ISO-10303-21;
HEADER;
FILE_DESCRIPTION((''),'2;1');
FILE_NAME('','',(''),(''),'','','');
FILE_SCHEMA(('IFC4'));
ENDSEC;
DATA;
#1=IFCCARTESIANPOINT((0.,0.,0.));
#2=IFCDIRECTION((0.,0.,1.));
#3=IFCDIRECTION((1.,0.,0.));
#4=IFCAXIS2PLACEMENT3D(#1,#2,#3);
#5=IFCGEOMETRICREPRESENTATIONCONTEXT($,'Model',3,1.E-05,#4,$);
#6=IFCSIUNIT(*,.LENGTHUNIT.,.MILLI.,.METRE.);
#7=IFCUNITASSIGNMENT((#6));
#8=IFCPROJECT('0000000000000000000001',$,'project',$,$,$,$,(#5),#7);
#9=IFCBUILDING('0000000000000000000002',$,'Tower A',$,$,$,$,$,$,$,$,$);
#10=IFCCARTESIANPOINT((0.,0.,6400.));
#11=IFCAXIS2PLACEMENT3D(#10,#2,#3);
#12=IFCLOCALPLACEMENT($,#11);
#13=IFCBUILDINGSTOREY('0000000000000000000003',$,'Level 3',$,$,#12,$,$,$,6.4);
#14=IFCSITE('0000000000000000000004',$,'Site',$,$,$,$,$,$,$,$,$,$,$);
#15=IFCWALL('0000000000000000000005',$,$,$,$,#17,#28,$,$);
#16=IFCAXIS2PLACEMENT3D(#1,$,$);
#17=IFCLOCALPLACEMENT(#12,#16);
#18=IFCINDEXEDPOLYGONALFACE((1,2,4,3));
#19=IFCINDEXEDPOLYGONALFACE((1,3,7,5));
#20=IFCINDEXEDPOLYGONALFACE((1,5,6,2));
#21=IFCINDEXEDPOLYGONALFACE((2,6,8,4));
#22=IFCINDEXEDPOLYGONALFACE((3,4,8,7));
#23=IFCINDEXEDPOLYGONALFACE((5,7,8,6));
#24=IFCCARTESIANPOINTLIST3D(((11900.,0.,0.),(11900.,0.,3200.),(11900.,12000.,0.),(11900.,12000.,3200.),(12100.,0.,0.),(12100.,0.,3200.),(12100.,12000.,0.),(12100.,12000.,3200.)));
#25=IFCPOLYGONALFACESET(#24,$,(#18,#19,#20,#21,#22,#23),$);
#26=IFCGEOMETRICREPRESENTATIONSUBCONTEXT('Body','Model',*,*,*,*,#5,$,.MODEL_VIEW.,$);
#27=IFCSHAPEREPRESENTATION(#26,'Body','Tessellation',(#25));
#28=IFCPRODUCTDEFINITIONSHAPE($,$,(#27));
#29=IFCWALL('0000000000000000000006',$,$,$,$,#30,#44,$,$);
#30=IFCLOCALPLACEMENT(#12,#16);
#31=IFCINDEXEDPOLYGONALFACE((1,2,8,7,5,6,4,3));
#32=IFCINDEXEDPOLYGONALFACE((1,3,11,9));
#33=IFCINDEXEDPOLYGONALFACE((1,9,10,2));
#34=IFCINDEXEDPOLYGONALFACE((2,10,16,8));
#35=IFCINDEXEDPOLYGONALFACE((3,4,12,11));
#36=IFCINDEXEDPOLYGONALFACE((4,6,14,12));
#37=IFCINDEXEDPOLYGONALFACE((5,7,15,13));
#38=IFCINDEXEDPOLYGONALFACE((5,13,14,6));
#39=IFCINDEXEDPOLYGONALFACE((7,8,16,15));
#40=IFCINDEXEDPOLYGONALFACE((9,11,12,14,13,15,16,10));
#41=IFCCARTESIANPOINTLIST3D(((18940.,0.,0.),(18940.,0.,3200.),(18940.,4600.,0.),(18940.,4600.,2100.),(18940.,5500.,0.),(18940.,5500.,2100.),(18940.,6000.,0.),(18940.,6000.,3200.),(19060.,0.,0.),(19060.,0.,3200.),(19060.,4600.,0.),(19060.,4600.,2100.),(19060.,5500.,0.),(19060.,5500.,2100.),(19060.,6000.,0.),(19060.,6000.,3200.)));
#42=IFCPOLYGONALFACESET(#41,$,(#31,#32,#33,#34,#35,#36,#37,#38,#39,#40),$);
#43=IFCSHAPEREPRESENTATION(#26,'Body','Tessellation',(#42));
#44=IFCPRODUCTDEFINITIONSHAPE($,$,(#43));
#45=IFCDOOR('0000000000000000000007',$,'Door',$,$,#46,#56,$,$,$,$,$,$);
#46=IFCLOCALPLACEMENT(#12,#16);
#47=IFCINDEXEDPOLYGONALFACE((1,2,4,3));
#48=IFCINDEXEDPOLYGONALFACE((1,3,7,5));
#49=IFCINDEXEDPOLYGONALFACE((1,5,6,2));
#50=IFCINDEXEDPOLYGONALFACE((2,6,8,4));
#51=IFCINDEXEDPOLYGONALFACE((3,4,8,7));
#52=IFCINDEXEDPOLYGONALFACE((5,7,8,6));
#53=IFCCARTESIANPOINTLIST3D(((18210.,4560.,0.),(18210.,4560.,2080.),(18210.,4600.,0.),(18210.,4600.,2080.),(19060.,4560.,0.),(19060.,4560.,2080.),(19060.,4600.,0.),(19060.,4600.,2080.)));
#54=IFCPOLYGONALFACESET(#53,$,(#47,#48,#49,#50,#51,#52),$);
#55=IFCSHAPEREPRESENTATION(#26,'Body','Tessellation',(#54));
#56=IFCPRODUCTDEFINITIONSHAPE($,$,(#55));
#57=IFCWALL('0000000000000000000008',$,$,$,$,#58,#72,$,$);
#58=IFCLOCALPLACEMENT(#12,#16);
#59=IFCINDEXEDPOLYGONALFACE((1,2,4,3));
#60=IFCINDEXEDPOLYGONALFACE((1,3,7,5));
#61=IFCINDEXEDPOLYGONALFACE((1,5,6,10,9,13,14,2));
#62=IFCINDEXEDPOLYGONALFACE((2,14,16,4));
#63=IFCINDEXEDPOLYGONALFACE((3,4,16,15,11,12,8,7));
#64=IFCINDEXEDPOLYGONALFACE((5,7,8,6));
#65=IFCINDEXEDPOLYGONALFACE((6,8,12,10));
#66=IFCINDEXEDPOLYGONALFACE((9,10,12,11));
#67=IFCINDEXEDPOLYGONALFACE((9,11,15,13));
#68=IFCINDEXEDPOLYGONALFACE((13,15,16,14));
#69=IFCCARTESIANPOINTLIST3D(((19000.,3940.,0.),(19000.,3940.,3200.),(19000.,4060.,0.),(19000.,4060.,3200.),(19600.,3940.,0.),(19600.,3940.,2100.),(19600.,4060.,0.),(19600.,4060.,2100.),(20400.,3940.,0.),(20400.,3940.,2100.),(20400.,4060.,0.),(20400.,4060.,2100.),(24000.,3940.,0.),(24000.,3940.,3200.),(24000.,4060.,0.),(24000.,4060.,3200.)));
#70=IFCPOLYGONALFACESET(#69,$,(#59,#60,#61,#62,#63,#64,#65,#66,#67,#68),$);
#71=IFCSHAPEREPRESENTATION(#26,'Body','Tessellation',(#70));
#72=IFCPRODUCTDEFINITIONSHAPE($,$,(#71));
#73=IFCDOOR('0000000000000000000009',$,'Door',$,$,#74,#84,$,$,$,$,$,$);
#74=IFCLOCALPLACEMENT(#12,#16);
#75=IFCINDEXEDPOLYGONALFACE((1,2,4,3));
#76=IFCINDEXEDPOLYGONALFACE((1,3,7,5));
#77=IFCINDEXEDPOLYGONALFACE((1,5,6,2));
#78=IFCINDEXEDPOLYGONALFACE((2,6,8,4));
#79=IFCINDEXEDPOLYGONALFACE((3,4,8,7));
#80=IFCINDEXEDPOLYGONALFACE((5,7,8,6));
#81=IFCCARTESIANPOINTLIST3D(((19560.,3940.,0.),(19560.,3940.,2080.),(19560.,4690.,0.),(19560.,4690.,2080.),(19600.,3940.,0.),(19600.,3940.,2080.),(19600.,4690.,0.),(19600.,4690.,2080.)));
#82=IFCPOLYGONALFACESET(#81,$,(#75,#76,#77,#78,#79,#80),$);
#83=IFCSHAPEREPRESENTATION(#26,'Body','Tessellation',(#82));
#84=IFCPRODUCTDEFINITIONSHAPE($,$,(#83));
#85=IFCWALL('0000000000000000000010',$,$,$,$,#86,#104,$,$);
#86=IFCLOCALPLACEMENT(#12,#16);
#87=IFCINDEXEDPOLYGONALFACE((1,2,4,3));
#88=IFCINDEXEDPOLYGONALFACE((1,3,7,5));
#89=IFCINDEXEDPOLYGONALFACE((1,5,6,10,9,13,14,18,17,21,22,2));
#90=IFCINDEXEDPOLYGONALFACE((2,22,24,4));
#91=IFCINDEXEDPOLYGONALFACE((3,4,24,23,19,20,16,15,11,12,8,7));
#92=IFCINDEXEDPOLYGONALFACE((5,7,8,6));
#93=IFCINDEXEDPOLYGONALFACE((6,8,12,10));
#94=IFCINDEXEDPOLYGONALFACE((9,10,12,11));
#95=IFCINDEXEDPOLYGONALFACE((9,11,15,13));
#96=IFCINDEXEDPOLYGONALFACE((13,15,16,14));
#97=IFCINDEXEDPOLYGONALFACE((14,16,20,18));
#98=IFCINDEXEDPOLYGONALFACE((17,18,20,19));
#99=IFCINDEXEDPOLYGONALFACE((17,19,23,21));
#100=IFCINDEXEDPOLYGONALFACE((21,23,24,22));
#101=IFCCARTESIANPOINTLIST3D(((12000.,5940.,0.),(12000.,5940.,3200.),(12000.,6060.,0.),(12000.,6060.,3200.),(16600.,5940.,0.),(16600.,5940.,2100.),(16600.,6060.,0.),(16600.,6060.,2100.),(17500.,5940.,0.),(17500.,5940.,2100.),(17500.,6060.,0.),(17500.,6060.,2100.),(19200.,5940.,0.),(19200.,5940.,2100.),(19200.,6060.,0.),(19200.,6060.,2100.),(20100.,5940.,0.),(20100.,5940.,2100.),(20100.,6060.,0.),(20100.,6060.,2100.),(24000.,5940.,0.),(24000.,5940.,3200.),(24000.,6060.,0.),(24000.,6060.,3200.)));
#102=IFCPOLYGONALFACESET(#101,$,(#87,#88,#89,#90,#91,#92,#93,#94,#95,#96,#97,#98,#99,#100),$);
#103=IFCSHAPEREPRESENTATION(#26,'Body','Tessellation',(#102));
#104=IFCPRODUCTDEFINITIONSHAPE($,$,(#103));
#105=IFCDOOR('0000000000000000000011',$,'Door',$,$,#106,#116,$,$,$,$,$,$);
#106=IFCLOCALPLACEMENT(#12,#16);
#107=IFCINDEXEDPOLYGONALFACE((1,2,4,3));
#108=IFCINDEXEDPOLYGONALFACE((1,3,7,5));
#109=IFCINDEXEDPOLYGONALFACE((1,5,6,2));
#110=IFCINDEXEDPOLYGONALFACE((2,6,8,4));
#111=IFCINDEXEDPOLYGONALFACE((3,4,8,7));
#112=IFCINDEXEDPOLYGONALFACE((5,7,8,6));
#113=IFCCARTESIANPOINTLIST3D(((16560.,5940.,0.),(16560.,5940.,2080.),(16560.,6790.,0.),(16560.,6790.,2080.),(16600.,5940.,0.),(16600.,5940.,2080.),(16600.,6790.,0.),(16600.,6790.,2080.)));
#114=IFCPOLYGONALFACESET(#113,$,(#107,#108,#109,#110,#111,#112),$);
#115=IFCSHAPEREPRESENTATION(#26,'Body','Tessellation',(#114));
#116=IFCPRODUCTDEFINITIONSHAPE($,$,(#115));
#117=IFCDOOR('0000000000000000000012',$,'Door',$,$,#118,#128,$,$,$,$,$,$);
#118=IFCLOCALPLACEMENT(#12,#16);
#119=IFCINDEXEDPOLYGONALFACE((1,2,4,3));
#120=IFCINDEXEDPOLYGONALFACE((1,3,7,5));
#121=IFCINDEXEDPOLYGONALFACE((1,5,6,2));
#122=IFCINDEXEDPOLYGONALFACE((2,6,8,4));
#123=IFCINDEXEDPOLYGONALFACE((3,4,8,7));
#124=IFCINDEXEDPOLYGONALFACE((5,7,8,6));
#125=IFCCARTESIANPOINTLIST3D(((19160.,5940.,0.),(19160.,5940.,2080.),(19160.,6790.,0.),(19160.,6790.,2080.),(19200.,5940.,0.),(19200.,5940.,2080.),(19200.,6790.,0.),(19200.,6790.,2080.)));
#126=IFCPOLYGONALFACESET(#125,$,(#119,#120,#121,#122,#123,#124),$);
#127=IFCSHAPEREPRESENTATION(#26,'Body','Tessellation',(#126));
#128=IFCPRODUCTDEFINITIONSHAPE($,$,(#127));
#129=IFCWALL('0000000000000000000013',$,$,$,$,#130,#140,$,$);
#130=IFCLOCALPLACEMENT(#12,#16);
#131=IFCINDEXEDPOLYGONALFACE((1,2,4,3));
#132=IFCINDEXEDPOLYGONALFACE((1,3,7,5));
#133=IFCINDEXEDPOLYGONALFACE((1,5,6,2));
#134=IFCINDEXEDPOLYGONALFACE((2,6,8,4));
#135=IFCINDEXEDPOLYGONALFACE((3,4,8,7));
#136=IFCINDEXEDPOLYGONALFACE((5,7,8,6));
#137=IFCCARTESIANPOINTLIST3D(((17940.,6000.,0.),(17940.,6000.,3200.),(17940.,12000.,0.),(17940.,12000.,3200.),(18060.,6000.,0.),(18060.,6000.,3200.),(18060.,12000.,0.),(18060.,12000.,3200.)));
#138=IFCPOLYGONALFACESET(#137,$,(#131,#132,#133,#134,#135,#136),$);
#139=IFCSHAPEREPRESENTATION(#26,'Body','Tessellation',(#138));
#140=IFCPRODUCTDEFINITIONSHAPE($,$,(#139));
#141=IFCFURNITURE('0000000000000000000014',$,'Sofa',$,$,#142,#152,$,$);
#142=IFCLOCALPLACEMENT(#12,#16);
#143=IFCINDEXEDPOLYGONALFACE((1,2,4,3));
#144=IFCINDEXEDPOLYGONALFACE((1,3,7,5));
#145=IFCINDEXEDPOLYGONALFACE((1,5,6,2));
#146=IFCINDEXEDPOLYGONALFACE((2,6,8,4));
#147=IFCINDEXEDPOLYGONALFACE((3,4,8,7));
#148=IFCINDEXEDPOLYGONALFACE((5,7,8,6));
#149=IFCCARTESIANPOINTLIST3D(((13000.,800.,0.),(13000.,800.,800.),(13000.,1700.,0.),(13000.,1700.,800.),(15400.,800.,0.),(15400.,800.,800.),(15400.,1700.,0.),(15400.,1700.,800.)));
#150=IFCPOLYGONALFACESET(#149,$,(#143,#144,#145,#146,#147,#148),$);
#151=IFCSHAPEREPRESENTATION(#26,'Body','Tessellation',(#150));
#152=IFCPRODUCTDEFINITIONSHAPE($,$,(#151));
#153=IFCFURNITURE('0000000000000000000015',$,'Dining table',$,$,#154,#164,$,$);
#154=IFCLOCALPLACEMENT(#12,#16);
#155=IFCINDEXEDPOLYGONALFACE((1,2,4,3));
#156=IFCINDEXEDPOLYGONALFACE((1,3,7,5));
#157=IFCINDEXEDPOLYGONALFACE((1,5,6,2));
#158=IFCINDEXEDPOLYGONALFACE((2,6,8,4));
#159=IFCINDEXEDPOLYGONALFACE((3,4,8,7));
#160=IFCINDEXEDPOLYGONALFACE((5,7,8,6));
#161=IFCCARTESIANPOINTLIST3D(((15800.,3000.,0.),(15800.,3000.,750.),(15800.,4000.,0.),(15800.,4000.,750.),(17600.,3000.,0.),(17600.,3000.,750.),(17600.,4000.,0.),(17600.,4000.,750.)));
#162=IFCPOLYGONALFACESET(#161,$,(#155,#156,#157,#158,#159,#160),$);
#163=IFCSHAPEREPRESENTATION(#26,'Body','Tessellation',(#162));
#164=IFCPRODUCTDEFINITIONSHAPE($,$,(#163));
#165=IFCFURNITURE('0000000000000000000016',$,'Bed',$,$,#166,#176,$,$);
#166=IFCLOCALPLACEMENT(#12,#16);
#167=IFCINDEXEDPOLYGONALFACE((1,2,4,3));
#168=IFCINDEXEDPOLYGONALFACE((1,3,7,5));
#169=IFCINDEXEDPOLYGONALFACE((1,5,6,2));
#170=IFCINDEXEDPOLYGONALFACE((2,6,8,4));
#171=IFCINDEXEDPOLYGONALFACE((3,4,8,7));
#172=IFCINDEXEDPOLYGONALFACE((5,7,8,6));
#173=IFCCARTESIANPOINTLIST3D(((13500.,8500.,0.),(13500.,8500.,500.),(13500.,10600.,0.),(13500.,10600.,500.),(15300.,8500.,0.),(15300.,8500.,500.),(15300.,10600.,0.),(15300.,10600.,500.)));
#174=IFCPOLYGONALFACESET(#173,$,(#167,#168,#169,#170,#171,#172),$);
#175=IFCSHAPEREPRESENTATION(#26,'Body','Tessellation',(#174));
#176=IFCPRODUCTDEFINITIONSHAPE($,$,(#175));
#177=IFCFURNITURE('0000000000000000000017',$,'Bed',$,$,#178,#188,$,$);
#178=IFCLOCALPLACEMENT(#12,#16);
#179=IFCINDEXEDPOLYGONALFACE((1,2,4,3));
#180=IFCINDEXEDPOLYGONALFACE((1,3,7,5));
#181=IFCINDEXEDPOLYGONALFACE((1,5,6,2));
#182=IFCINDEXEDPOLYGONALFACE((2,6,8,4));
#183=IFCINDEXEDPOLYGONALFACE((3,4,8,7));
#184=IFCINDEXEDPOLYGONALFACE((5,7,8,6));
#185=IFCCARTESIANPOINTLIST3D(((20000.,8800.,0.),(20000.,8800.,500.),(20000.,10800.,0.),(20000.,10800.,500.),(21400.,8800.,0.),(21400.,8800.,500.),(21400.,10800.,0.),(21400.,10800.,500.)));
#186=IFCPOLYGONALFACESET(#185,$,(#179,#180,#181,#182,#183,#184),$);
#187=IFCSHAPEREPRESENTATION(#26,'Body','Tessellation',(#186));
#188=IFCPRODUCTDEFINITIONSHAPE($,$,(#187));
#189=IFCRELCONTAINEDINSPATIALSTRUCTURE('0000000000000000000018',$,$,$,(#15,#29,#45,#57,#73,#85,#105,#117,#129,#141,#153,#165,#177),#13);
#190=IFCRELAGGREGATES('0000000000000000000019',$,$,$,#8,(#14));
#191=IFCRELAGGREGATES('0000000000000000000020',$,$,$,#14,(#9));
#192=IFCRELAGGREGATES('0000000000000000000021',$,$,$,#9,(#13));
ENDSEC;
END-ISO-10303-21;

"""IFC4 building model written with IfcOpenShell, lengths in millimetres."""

from ifc_helpers import new_model, si_unit, frame, origin_with_axes, place, context, subcontext, project, spatial, indexed_curve, outline, extrude, element, fill, save


model = new_model("IFC4")

# Units and contexts
model_context = context("Model", 3, precision=1e-05, world=origin_with_axes())
body_context = subcontext(model_context, "Body", "Model", "MODEL_VIEW")
ifc_project = project(units=[si_unit("LENGTHUNIT", "METRE", prefix="MILLI")], contexts=[model_context])

# Site, building, storey
site = spatial("IfcSite", under=ifc_project, Name="Site")
building = spatial("IfcBuilding", under=site, Name="Tower A")
storey_placement = place(None, frame((0.0, 0.0, 6400.0), z_axis=(0.0, 0.0, 1.0), x_axis=(1.0, 0.0, 0.0)))
storey = spatial("IfcBuildingStorey", under=building, at=storey_placement, Name="Level 3", Elevation=6.4)

# Wall
wall_1_placement = place(storey_placement, frame((12100.0, 0.0, 0.0), z_axis=(0.0, 0.0, 1.0), x_axis=(0.0, 1.0, 0.0)))
element("IfcWall", 1, at=wall_1_placement, inside=storey, context=body_context, shape_type="SweptSolid", body=[
    extrude(outline(indexed_curve([(0.0, 0.0), (0.0, 200.0), (12000.0, 200.0), (12000.0, 0.0), (0.0, 0.0)], self_intersect=False)), origin_with_axes(), (0.0, 0.0, 1.0), 3200.0),
])

# Walls, openings, doors
wall_2_placement = place(storey_placement, frame((19060.0, 0.0, 0.0), z_axis=(0.0, 0.0, 1.0), x_axis=(0.0, 1.0, 0.0)))
wall_2 = element("IfcWall", 2, at=wall_2_placement, inside=storey, context=body_context, shape_type="SweptSolid", body=[
    extrude(outline(indexed_curve([(0.0, 0.0), (0.0, 120.0), (6000.0, 120.0), (6000.0, 0.0), (0.0, 0.0)], self_intersect=False)), origin_with_axes(), (0.0, 0.0, 1.0), 3200.0),
])
opening_1_placement = place(wall_2_placement, frame((4600.0, 0.0, 0.0), z_axis=(0.0, 0.0, 1.0), x_axis=(1.0, 0.0, 0.0)))
opening_1 = element("IfcOpeningElement", 3, at=opening_1_placement, cuts=wall_2, context=body_context, shape_type="SweptSolid", body=[
    extrude(outline(indexed_curve([(0.0, 0.0), (0.0, 120.0), (900.0, 120.0), (900.0, 0.0), (0.0, 0.0)], self_intersect=False)), origin_with_axes(), (0.0, 0.0, 1.0), 2100.0),
])
door_1_placement = place(storey_placement, frame((19060.0, 4600.0, 0.0), z_axis=(0.0, 0.0, 1.0), x_axis=(-1.0, 0.0, 0.0)))
door_1 = element("IfcDoor", 4, at=door_1_placement, inside=storey, Name="Door", context=body_context, shape_type="SweptSolid", body=[
    extrude(outline(indexed_curve([(0.0, 0.0), (0.0, 40.0), (850.0, 40.0), (850.0, 0.0), (0.0, 0.0)], self_intersect=False)), origin_with_axes(), (0.0, 0.0, 1.0), 2080.0),
])
fill(opening_1, door_1)
wall_3_placement = place(storey_placement, frame((19000.0, 3940.0, 0.0), z_axis=(0.0, 0.0, 1.0), x_axis=(1.0, 0.0, 0.0)))
wall_3 = element("IfcWall", 5, at=wall_3_placement, inside=storey, context=body_context, shape_type="SweptSolid", body=[
    extrude(outline(indexed_curve([(0.0, 0.0), (0.0, 120.0), (5000.0, 120.0), (5000.0, 0.0), (0.0, 0.0)], self_intersect=False)), origin_with_axes(), (0.0, 0.0, 1.0), 3200.0),
])
opening_2_placement = place(wall_3_placement, frame((600.0, 0.0, 0.0), z_axis=(0.0, 0.0, 1.0), x_axis=(1.0, 0.0, 0.0)))
opening_2 = element("IfcOpeningElement", 6, at=opening_2_placement, cuts=wall_3, context=body_context, shape_type="SweptSolid", body=[
    extrude(outline(indexed_curve([(0.0, 0.0), (0.0, 120.0), (800.0, 120.0), (800.0, 0.0), (0.0, 0.0)], self_intersect=False)), origin_with_axes(), (0.0, 0.0, 1.0), 2100.0),
])
door_2_placement = place(storey_placement, frame((19600.0, 3940.0, 0.0), z_axis=(0.0, 0.0, 1.0), x_axis=(0.0, 1.0, 0.0)))
door_2 = element("IfcDoor", 7, at=door_2_placement, inside=storey, Name="Door", context=body_context, shape_type="SweptSolid", body=[
    extrude(outline(indexed_curve([(0.0, 0.0), (0.0, 40.0), (750.0, 40.0), (750.0, 0.0), (0.0, 0.0)], self_intersect=False)), origin_with_axes(), (0.0, 0.0, 1.0), 2080.0),
])
fill(opening_2, door_2)

# Wall, openings, doors
wall_4_placement = place(storey_placement, frame((12000.0, 5940.0, 0.0), z_axis=(0.0, 0.0, 1.0), x_axis=(1.0, 0.0, 0.0)))
wall_4 = element("IfcWall", 8, at=wall_4_placement, inside=storey, context=body_context, shape_type="SweptSolid", body=[
    extrude(outline(indexed_curve([(0.0, 0.0), (0.0, 120.0), (12000.0, 120.0), (12000.0, 0.0), (0.0, 0.0)], self_intersect=False)), origin_with_axes(), (0.0, 0.0, 1.0), 3200.0),
])
opening_3_placement = place(wall_4_placement, frame((4600.0, 0.0, 0.0), z_axis=(0.0, 0.0, 1.0), x_axis=(1.0, 0.0, 0.0)))
opening_3 = element("IfcOpeningElement", 9, at=opening_3_placement, cuts=wall_4, context=body_context, shape_type="SweptSolid", body=[
    extrude(outline(indexed_curve([(0.0, 0.0), (0.0, 120.0), (900.0, 120.0), (900.0, 0.0), (0.0, 0.0)], self_intersect=False)), origin_with_axes(), (0.0, 0.0, 1.0), 2100.0),
])
opening_4_placement = place(wall_4_placement, frame((7200.0, 0.0, 0.0), z_axis=(0.0, 0.0, 1.0), x_axis=(1.0, 0.0, 0.0)))
opening_4 = element("IfcOpeningElement", 10, at=opening_4_placement, cuts=wall_4, context=body_context, shape_type="SweptSolid", body=[
    extrude(outline(indexed_curve([(0.0, 0.0), (0.0, 120.0), (900.0, 120.0), (900.0, 0.0), (0.0, 0.0)], self_intersect=False)), origin_with_axes(), (0.0, 0.0, 1.0), 2100.0),
])
door_3_placement = place(storey_placement, frame((16600.0, 5940.0, 0.0), z_axis=(0.0, 0.0, 1.0), x_axis=(0.0, 1.0, 0.0)))
door_3 = element("IfcDoor", 11, at=door_3_placement, inside=storey, Name="Door", context=body_context, shape_type="SweptSolid", body=[
    extrude(outline(indexed_curve([(0.0, 0.0), (0.0, 40.0), (850.0, 40.0), (850.0, 0.0), (0.0, 0.0)], self_intersect=False)), origin_with_axes(), (0.0, 0.0, 1.0), 2080.0),
])
fill(opening_3, door_3)
door_4_placement = place(storey_placement, frame((19200.0, 5940.0, 0.0), z_axis=(0.0, 0.0, 1.0), x_axis=(0.0, 1.0, 0.0)))
door_4 = element("IfcDoor", 12, at=door_4_placement, inside=storey, Name="Door", context=body_context, shape_type="SweptSolid", body=[
    extrude(outline(indexed_curve([(0.0, 0.0), (0.0, 40.0), (850.0, 40.0), (850.0, 0.0), (0.0, 0.0)], self_intersect=False)), origin_with_axes(), (0.0, 0.0, 1.0), 2080.0),
])
fill(opening_4, door_4)

# Wall
wall_5_placement = place(storey_placement, frame((18060.0, 6000.0, 0.0), z_axis=(0.0, 0.0, 1.0), x_axis=(0.0, 1.0, 0.0)))
element("IfcWall", 13, at=wall_5_placement, inside=storey, context=body_context, shape_type="SweptSolid", body=[
    extrude(outline(indexed_curve([(0.0, 0.0), (0.0, 120.0), (6000.0, 120.0), (6000.0, 0.0), (0.0, 0.0)], self_intersect=False)), origin_with_axes(), (0.0, 0.0, 1.0), 3200.0),
])

# Furniture
furniture_1_placement = place(storey_placement, frame((13000.0, 800.0, 0.0), z_axis=(0.0, 0.0, 1.0), x_axis=(1.0, 0.0, 0.0)))
element("IfcFurniture", 14, at=furniture_1_placement, inside=storey, Name="Sofa", context=body_context, shape_type="SweptSolid", body=[
    extrude(outline(indexed_curve([(0.0, 0.0), (2400.0, 0.0), (2400.0, 900.0), (0.0, 900.0)])), None, (0.0, 0.0, 1.0), 800.0),
])
furniture_2_placement = place(storey_placement, frame((15800.0, 3000.0, 0.0), z_axis=(0.0, 0.0, 1.0), x_axis=(1.0, 0.0, 0.0)))
element("IfcFurniture", 15, at=furniture_2_placement, inside=storey, Name="Dining table", context=body_context, shape_type="SweptSolid", body=[
    extrude(outline(indexed_curve([(0.0, 0.0), (1800.0, 0.0), (1800.0, 1000.0), (0.0, 1000.0)])), None, (0.0, 0.0, 1.0), 750.0),
])
furniture_3_placement = place(storey_placement, frame((13500.0, 8500.0, 0.0), z_axis=(0.0, 0.0, 1.0), x_axis=(1.0, 0.0, 0.0)))
element("IfcFurniture", 16, at=furniture_3_placement, inside=storey, Name="Bed", context=body_context, shape_type="SweptSolid", body=[
    extrude(outline(indexed_curve([(0.0, 0.0), (1800.0, 0.0), (1800.0, 2100.0), (0.0, 2100.0)])), None, (0.0, 0.0, 1.0), 500.0),
])
furniture_4_placement = place(storey_placement, frame((20000.0, 8800.0, 0.0), z_axis=(0.0, 0.0, 1.0), x_axis=(1.0, 0.0, 0.0)))
element("IfcFurniture", 17, at=furniture_4_placement, inside=storey, Name="Bed", context=body_context, shape_type="SweptSolid", body=[
    extrude(outline(indexed_curve([(0.0, 0.0), (1400.0, 0.0), (1400.0, 2000.0), (0.0, 2000.0)])), None, (0.0, 0.0, 1.0), 500.0),
])

save(model, "model.ifc")
